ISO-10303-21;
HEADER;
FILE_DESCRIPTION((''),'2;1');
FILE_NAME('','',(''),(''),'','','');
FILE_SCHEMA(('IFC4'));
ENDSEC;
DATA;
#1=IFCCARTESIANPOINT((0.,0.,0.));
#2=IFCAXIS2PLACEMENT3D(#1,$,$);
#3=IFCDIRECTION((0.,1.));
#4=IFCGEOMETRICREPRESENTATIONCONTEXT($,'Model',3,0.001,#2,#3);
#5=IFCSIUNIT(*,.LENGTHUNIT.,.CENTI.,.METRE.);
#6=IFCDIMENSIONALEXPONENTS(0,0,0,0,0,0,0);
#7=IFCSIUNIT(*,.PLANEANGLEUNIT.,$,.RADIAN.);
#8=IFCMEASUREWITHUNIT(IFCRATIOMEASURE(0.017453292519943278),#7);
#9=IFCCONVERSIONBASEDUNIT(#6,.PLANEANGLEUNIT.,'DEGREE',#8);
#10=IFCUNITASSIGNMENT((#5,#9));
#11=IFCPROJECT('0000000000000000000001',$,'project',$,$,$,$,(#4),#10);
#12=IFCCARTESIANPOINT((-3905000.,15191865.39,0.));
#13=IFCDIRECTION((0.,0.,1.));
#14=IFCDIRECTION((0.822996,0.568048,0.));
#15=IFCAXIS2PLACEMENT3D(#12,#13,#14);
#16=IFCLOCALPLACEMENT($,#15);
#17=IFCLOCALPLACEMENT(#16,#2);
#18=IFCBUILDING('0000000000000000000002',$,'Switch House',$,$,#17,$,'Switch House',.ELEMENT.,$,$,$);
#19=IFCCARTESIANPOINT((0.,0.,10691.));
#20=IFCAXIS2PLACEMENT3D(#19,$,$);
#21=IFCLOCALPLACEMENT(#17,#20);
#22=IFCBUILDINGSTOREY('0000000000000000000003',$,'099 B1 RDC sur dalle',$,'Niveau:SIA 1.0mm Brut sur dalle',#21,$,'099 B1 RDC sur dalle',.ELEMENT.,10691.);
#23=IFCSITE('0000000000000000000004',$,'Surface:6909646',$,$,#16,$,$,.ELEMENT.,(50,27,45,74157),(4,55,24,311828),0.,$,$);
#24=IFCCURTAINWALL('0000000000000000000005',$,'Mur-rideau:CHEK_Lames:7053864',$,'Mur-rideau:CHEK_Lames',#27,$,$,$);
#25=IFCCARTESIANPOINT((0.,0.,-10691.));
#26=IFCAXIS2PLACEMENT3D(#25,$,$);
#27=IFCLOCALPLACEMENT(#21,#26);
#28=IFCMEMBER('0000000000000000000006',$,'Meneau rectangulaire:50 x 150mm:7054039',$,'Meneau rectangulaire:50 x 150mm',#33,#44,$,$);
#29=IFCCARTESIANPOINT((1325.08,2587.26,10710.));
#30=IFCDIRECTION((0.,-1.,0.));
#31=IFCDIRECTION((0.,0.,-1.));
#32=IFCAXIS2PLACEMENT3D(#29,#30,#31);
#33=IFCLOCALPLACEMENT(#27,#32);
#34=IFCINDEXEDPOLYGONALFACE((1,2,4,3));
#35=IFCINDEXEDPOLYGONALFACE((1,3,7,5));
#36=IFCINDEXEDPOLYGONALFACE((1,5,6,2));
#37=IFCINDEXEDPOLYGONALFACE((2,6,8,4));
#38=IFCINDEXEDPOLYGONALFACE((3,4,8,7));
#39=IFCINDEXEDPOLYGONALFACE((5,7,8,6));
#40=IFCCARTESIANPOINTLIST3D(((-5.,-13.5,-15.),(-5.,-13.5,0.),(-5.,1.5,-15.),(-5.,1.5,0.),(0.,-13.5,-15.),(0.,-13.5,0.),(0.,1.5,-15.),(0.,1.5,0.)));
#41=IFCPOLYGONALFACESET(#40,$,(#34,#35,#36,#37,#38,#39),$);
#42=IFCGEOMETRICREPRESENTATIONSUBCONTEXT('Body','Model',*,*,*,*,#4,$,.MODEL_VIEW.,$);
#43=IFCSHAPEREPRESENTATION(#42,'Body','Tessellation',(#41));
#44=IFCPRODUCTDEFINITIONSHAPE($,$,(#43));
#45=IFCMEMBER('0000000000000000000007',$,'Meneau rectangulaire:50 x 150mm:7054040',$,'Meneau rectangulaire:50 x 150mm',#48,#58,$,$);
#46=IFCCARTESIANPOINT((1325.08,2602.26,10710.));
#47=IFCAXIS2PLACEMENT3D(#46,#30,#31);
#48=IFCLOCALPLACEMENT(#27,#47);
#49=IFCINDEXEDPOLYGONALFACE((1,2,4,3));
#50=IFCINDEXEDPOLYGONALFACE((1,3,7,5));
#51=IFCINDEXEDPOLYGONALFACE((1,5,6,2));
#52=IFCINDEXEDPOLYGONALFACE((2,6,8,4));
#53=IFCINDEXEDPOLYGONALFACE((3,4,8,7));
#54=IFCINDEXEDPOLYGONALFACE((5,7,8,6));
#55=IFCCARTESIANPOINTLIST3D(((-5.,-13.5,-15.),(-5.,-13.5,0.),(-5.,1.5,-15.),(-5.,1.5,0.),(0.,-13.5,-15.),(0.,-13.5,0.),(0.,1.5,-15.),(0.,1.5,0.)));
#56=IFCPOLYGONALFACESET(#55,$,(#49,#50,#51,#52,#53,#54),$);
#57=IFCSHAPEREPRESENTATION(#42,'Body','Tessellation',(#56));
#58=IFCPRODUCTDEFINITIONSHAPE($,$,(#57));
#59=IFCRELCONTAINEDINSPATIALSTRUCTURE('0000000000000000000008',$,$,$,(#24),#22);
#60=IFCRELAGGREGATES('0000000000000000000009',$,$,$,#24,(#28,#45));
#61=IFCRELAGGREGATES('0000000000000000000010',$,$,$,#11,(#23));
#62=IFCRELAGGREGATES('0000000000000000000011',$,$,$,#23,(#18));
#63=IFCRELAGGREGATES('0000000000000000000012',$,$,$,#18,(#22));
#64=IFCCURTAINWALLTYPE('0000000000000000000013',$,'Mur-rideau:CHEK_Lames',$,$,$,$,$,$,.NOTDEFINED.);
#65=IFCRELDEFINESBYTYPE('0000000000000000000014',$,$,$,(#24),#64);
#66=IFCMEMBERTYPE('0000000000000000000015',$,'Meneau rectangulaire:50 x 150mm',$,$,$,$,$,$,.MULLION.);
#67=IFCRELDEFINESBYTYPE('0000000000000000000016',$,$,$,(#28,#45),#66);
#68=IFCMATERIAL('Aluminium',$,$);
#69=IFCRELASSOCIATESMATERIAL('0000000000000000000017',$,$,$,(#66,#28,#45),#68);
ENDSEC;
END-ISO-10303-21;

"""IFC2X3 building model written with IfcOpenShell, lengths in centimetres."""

from ifc_helpers import new_model, entity, si_unit, converted_unit, direction, frame, origin, origin_2d_with_axis, place, context, subcontext, project, spatial, rectangle, extrude, source, transform, mapped, material, type_object, type_shapes, element, aggregate, save


model = new_model("IFC2X3")

# Units and contexts
model_context = context("Model", 3, precision=0.001, world=origin(), true_north=direction((0.0, 1.0)))
body_context = subcontext(model_context, "Body", "Model", "MODEL_VIEW")
ifc_project = project(units=[si_unit("LENGTHUNIT", "METRE", prefix="CENTI"), converted_unit("PLANEANGLEUNIT", "DEGREE", entity("IfcRatioMeasure", 0.017453292519943278), si_unit("PLANEANGLEUNIT", "RADIAN"), dimensions=[0, 0, 0, 0, 0, 0, 0])], contexts=[model_context])

# Site, building, storey
site_placement = place(None, frame((-3905000.0, 15191865.39, 0.0), z_axis=(0.0, 0.0, 1.0), x_axis=(0.822996, 0.568048, 0.0)))
site = spatial("IfcSite", under=ifc_project, at=site_placement, Name="Surface:6909646", CompositionType="ELEMENT", RefLatitude=(50, 27, 45, 74157), RefLongitude=(4, 55, 24, 311828), RefElevation=0.0)
building_placement = place(site_placement, origin())
building = spatial("IfcBuilding", under=site, at=building_placement, Name="Switch House", LongName="Switch House", CompositionType="ELEMENT")
storey_placement = place(building_placement, frame((0.0, 0.0, 10691.0)))
storey = spatial("IfcBuildingStorey", under=building, at=storey_placement, Name="099 B1 RDC sur dalle", ObjectType="Niveau:SIA 1.0mm Brut sur dalle", LongName="099 B1 RDC sur dalle", CompositionType="ELEMENT", Elevation=10691.0)

# Curtain wall
curtain_wall_type_1 = type_object("IfcCurtainWallType", Name="Mur-rideau:CHEK_Lames", PredefinedType="NOTDEFINED")
curtain_wall_1_placement = place(storey_placement, frame((0.0, 0.0, -10691.0)))
curtain_wall_1 = element("IfcCurtainWall", 1, at=curtain_wall_1_placement, inside=storey, type_object=curtain_wall_type_1, Name="Mur-rideau:CHEK_Lames:7053864", ObjectType="Mur-rideau:CHEK_Lames")
ifc_material_1 = material(Name="Aluminium")

# Members
member_type_1 = type_object("IfcMemberType", Name="Meneau rectangulaire:50 x 150mm", PredefinedType="MULLION", material=ifc_material_1)
shared_shape_1 = source(origin(), body_context, "Body", "SweptSolid", [
    extrude(rectangle(XDim=15.0, YDim=5.0, at=origin_2d_with_axis()), frame((-2.5, -6.0, -15.0), z_axis=(0.0, 0.0, 1.0), x_axis=(0.0, -1.0, 0.0)), (0.0, 0.0, 1.0), 15.0),
])
type_shapes(member_type_1, [shared_shape_1])
member_1_placement = place(curtain_wall_1_placement, frame((1325.08, 2587.26, 10710.0), z_axis=(0.0, -1.0, 0.0), x_axis=(0.0, 0.0, -1.0)))
member_1 = element("IfcMember", 2, at=member_1_placement, type_object=member_type_1, material=ifc_material_1, Name="Meneau rectangulaire:50 x 150mm:7054039", ObjectType="Meneau rectangulaire:50 x 150mm", context=body_context, shape_type="MappedRepresentation", body=[
    mapped(shared_shape_1, transform((0.0, 0.0, 0.0), scale=1.0)),
])
member_2_placement = place(curtain_wall_1_placement, frame((1325.08, 2602.26, 10710.0), z_axis=(0.0, -1.0, 0.0), x_axis=(0.0, 0.0, -1.0)))
member_2 = element("IfcMember", 3, at=member_2_placement, type_object=member_type_1, material=ifc_material_1, Name="Meneau rectangulaire:50 x 150mm:7054040", ObjectType="Meneau rectangulaire:50 x 150mm", context=body_context, shape_type="MappedRepresentation", body=[
    mapped(shared_shape_1, transform((0.0, 0.0, 0.0), scale=1.0)),
])
aggregate(curtain_wall_1, [member_1, member_2])

save(model, "model.ifc")
